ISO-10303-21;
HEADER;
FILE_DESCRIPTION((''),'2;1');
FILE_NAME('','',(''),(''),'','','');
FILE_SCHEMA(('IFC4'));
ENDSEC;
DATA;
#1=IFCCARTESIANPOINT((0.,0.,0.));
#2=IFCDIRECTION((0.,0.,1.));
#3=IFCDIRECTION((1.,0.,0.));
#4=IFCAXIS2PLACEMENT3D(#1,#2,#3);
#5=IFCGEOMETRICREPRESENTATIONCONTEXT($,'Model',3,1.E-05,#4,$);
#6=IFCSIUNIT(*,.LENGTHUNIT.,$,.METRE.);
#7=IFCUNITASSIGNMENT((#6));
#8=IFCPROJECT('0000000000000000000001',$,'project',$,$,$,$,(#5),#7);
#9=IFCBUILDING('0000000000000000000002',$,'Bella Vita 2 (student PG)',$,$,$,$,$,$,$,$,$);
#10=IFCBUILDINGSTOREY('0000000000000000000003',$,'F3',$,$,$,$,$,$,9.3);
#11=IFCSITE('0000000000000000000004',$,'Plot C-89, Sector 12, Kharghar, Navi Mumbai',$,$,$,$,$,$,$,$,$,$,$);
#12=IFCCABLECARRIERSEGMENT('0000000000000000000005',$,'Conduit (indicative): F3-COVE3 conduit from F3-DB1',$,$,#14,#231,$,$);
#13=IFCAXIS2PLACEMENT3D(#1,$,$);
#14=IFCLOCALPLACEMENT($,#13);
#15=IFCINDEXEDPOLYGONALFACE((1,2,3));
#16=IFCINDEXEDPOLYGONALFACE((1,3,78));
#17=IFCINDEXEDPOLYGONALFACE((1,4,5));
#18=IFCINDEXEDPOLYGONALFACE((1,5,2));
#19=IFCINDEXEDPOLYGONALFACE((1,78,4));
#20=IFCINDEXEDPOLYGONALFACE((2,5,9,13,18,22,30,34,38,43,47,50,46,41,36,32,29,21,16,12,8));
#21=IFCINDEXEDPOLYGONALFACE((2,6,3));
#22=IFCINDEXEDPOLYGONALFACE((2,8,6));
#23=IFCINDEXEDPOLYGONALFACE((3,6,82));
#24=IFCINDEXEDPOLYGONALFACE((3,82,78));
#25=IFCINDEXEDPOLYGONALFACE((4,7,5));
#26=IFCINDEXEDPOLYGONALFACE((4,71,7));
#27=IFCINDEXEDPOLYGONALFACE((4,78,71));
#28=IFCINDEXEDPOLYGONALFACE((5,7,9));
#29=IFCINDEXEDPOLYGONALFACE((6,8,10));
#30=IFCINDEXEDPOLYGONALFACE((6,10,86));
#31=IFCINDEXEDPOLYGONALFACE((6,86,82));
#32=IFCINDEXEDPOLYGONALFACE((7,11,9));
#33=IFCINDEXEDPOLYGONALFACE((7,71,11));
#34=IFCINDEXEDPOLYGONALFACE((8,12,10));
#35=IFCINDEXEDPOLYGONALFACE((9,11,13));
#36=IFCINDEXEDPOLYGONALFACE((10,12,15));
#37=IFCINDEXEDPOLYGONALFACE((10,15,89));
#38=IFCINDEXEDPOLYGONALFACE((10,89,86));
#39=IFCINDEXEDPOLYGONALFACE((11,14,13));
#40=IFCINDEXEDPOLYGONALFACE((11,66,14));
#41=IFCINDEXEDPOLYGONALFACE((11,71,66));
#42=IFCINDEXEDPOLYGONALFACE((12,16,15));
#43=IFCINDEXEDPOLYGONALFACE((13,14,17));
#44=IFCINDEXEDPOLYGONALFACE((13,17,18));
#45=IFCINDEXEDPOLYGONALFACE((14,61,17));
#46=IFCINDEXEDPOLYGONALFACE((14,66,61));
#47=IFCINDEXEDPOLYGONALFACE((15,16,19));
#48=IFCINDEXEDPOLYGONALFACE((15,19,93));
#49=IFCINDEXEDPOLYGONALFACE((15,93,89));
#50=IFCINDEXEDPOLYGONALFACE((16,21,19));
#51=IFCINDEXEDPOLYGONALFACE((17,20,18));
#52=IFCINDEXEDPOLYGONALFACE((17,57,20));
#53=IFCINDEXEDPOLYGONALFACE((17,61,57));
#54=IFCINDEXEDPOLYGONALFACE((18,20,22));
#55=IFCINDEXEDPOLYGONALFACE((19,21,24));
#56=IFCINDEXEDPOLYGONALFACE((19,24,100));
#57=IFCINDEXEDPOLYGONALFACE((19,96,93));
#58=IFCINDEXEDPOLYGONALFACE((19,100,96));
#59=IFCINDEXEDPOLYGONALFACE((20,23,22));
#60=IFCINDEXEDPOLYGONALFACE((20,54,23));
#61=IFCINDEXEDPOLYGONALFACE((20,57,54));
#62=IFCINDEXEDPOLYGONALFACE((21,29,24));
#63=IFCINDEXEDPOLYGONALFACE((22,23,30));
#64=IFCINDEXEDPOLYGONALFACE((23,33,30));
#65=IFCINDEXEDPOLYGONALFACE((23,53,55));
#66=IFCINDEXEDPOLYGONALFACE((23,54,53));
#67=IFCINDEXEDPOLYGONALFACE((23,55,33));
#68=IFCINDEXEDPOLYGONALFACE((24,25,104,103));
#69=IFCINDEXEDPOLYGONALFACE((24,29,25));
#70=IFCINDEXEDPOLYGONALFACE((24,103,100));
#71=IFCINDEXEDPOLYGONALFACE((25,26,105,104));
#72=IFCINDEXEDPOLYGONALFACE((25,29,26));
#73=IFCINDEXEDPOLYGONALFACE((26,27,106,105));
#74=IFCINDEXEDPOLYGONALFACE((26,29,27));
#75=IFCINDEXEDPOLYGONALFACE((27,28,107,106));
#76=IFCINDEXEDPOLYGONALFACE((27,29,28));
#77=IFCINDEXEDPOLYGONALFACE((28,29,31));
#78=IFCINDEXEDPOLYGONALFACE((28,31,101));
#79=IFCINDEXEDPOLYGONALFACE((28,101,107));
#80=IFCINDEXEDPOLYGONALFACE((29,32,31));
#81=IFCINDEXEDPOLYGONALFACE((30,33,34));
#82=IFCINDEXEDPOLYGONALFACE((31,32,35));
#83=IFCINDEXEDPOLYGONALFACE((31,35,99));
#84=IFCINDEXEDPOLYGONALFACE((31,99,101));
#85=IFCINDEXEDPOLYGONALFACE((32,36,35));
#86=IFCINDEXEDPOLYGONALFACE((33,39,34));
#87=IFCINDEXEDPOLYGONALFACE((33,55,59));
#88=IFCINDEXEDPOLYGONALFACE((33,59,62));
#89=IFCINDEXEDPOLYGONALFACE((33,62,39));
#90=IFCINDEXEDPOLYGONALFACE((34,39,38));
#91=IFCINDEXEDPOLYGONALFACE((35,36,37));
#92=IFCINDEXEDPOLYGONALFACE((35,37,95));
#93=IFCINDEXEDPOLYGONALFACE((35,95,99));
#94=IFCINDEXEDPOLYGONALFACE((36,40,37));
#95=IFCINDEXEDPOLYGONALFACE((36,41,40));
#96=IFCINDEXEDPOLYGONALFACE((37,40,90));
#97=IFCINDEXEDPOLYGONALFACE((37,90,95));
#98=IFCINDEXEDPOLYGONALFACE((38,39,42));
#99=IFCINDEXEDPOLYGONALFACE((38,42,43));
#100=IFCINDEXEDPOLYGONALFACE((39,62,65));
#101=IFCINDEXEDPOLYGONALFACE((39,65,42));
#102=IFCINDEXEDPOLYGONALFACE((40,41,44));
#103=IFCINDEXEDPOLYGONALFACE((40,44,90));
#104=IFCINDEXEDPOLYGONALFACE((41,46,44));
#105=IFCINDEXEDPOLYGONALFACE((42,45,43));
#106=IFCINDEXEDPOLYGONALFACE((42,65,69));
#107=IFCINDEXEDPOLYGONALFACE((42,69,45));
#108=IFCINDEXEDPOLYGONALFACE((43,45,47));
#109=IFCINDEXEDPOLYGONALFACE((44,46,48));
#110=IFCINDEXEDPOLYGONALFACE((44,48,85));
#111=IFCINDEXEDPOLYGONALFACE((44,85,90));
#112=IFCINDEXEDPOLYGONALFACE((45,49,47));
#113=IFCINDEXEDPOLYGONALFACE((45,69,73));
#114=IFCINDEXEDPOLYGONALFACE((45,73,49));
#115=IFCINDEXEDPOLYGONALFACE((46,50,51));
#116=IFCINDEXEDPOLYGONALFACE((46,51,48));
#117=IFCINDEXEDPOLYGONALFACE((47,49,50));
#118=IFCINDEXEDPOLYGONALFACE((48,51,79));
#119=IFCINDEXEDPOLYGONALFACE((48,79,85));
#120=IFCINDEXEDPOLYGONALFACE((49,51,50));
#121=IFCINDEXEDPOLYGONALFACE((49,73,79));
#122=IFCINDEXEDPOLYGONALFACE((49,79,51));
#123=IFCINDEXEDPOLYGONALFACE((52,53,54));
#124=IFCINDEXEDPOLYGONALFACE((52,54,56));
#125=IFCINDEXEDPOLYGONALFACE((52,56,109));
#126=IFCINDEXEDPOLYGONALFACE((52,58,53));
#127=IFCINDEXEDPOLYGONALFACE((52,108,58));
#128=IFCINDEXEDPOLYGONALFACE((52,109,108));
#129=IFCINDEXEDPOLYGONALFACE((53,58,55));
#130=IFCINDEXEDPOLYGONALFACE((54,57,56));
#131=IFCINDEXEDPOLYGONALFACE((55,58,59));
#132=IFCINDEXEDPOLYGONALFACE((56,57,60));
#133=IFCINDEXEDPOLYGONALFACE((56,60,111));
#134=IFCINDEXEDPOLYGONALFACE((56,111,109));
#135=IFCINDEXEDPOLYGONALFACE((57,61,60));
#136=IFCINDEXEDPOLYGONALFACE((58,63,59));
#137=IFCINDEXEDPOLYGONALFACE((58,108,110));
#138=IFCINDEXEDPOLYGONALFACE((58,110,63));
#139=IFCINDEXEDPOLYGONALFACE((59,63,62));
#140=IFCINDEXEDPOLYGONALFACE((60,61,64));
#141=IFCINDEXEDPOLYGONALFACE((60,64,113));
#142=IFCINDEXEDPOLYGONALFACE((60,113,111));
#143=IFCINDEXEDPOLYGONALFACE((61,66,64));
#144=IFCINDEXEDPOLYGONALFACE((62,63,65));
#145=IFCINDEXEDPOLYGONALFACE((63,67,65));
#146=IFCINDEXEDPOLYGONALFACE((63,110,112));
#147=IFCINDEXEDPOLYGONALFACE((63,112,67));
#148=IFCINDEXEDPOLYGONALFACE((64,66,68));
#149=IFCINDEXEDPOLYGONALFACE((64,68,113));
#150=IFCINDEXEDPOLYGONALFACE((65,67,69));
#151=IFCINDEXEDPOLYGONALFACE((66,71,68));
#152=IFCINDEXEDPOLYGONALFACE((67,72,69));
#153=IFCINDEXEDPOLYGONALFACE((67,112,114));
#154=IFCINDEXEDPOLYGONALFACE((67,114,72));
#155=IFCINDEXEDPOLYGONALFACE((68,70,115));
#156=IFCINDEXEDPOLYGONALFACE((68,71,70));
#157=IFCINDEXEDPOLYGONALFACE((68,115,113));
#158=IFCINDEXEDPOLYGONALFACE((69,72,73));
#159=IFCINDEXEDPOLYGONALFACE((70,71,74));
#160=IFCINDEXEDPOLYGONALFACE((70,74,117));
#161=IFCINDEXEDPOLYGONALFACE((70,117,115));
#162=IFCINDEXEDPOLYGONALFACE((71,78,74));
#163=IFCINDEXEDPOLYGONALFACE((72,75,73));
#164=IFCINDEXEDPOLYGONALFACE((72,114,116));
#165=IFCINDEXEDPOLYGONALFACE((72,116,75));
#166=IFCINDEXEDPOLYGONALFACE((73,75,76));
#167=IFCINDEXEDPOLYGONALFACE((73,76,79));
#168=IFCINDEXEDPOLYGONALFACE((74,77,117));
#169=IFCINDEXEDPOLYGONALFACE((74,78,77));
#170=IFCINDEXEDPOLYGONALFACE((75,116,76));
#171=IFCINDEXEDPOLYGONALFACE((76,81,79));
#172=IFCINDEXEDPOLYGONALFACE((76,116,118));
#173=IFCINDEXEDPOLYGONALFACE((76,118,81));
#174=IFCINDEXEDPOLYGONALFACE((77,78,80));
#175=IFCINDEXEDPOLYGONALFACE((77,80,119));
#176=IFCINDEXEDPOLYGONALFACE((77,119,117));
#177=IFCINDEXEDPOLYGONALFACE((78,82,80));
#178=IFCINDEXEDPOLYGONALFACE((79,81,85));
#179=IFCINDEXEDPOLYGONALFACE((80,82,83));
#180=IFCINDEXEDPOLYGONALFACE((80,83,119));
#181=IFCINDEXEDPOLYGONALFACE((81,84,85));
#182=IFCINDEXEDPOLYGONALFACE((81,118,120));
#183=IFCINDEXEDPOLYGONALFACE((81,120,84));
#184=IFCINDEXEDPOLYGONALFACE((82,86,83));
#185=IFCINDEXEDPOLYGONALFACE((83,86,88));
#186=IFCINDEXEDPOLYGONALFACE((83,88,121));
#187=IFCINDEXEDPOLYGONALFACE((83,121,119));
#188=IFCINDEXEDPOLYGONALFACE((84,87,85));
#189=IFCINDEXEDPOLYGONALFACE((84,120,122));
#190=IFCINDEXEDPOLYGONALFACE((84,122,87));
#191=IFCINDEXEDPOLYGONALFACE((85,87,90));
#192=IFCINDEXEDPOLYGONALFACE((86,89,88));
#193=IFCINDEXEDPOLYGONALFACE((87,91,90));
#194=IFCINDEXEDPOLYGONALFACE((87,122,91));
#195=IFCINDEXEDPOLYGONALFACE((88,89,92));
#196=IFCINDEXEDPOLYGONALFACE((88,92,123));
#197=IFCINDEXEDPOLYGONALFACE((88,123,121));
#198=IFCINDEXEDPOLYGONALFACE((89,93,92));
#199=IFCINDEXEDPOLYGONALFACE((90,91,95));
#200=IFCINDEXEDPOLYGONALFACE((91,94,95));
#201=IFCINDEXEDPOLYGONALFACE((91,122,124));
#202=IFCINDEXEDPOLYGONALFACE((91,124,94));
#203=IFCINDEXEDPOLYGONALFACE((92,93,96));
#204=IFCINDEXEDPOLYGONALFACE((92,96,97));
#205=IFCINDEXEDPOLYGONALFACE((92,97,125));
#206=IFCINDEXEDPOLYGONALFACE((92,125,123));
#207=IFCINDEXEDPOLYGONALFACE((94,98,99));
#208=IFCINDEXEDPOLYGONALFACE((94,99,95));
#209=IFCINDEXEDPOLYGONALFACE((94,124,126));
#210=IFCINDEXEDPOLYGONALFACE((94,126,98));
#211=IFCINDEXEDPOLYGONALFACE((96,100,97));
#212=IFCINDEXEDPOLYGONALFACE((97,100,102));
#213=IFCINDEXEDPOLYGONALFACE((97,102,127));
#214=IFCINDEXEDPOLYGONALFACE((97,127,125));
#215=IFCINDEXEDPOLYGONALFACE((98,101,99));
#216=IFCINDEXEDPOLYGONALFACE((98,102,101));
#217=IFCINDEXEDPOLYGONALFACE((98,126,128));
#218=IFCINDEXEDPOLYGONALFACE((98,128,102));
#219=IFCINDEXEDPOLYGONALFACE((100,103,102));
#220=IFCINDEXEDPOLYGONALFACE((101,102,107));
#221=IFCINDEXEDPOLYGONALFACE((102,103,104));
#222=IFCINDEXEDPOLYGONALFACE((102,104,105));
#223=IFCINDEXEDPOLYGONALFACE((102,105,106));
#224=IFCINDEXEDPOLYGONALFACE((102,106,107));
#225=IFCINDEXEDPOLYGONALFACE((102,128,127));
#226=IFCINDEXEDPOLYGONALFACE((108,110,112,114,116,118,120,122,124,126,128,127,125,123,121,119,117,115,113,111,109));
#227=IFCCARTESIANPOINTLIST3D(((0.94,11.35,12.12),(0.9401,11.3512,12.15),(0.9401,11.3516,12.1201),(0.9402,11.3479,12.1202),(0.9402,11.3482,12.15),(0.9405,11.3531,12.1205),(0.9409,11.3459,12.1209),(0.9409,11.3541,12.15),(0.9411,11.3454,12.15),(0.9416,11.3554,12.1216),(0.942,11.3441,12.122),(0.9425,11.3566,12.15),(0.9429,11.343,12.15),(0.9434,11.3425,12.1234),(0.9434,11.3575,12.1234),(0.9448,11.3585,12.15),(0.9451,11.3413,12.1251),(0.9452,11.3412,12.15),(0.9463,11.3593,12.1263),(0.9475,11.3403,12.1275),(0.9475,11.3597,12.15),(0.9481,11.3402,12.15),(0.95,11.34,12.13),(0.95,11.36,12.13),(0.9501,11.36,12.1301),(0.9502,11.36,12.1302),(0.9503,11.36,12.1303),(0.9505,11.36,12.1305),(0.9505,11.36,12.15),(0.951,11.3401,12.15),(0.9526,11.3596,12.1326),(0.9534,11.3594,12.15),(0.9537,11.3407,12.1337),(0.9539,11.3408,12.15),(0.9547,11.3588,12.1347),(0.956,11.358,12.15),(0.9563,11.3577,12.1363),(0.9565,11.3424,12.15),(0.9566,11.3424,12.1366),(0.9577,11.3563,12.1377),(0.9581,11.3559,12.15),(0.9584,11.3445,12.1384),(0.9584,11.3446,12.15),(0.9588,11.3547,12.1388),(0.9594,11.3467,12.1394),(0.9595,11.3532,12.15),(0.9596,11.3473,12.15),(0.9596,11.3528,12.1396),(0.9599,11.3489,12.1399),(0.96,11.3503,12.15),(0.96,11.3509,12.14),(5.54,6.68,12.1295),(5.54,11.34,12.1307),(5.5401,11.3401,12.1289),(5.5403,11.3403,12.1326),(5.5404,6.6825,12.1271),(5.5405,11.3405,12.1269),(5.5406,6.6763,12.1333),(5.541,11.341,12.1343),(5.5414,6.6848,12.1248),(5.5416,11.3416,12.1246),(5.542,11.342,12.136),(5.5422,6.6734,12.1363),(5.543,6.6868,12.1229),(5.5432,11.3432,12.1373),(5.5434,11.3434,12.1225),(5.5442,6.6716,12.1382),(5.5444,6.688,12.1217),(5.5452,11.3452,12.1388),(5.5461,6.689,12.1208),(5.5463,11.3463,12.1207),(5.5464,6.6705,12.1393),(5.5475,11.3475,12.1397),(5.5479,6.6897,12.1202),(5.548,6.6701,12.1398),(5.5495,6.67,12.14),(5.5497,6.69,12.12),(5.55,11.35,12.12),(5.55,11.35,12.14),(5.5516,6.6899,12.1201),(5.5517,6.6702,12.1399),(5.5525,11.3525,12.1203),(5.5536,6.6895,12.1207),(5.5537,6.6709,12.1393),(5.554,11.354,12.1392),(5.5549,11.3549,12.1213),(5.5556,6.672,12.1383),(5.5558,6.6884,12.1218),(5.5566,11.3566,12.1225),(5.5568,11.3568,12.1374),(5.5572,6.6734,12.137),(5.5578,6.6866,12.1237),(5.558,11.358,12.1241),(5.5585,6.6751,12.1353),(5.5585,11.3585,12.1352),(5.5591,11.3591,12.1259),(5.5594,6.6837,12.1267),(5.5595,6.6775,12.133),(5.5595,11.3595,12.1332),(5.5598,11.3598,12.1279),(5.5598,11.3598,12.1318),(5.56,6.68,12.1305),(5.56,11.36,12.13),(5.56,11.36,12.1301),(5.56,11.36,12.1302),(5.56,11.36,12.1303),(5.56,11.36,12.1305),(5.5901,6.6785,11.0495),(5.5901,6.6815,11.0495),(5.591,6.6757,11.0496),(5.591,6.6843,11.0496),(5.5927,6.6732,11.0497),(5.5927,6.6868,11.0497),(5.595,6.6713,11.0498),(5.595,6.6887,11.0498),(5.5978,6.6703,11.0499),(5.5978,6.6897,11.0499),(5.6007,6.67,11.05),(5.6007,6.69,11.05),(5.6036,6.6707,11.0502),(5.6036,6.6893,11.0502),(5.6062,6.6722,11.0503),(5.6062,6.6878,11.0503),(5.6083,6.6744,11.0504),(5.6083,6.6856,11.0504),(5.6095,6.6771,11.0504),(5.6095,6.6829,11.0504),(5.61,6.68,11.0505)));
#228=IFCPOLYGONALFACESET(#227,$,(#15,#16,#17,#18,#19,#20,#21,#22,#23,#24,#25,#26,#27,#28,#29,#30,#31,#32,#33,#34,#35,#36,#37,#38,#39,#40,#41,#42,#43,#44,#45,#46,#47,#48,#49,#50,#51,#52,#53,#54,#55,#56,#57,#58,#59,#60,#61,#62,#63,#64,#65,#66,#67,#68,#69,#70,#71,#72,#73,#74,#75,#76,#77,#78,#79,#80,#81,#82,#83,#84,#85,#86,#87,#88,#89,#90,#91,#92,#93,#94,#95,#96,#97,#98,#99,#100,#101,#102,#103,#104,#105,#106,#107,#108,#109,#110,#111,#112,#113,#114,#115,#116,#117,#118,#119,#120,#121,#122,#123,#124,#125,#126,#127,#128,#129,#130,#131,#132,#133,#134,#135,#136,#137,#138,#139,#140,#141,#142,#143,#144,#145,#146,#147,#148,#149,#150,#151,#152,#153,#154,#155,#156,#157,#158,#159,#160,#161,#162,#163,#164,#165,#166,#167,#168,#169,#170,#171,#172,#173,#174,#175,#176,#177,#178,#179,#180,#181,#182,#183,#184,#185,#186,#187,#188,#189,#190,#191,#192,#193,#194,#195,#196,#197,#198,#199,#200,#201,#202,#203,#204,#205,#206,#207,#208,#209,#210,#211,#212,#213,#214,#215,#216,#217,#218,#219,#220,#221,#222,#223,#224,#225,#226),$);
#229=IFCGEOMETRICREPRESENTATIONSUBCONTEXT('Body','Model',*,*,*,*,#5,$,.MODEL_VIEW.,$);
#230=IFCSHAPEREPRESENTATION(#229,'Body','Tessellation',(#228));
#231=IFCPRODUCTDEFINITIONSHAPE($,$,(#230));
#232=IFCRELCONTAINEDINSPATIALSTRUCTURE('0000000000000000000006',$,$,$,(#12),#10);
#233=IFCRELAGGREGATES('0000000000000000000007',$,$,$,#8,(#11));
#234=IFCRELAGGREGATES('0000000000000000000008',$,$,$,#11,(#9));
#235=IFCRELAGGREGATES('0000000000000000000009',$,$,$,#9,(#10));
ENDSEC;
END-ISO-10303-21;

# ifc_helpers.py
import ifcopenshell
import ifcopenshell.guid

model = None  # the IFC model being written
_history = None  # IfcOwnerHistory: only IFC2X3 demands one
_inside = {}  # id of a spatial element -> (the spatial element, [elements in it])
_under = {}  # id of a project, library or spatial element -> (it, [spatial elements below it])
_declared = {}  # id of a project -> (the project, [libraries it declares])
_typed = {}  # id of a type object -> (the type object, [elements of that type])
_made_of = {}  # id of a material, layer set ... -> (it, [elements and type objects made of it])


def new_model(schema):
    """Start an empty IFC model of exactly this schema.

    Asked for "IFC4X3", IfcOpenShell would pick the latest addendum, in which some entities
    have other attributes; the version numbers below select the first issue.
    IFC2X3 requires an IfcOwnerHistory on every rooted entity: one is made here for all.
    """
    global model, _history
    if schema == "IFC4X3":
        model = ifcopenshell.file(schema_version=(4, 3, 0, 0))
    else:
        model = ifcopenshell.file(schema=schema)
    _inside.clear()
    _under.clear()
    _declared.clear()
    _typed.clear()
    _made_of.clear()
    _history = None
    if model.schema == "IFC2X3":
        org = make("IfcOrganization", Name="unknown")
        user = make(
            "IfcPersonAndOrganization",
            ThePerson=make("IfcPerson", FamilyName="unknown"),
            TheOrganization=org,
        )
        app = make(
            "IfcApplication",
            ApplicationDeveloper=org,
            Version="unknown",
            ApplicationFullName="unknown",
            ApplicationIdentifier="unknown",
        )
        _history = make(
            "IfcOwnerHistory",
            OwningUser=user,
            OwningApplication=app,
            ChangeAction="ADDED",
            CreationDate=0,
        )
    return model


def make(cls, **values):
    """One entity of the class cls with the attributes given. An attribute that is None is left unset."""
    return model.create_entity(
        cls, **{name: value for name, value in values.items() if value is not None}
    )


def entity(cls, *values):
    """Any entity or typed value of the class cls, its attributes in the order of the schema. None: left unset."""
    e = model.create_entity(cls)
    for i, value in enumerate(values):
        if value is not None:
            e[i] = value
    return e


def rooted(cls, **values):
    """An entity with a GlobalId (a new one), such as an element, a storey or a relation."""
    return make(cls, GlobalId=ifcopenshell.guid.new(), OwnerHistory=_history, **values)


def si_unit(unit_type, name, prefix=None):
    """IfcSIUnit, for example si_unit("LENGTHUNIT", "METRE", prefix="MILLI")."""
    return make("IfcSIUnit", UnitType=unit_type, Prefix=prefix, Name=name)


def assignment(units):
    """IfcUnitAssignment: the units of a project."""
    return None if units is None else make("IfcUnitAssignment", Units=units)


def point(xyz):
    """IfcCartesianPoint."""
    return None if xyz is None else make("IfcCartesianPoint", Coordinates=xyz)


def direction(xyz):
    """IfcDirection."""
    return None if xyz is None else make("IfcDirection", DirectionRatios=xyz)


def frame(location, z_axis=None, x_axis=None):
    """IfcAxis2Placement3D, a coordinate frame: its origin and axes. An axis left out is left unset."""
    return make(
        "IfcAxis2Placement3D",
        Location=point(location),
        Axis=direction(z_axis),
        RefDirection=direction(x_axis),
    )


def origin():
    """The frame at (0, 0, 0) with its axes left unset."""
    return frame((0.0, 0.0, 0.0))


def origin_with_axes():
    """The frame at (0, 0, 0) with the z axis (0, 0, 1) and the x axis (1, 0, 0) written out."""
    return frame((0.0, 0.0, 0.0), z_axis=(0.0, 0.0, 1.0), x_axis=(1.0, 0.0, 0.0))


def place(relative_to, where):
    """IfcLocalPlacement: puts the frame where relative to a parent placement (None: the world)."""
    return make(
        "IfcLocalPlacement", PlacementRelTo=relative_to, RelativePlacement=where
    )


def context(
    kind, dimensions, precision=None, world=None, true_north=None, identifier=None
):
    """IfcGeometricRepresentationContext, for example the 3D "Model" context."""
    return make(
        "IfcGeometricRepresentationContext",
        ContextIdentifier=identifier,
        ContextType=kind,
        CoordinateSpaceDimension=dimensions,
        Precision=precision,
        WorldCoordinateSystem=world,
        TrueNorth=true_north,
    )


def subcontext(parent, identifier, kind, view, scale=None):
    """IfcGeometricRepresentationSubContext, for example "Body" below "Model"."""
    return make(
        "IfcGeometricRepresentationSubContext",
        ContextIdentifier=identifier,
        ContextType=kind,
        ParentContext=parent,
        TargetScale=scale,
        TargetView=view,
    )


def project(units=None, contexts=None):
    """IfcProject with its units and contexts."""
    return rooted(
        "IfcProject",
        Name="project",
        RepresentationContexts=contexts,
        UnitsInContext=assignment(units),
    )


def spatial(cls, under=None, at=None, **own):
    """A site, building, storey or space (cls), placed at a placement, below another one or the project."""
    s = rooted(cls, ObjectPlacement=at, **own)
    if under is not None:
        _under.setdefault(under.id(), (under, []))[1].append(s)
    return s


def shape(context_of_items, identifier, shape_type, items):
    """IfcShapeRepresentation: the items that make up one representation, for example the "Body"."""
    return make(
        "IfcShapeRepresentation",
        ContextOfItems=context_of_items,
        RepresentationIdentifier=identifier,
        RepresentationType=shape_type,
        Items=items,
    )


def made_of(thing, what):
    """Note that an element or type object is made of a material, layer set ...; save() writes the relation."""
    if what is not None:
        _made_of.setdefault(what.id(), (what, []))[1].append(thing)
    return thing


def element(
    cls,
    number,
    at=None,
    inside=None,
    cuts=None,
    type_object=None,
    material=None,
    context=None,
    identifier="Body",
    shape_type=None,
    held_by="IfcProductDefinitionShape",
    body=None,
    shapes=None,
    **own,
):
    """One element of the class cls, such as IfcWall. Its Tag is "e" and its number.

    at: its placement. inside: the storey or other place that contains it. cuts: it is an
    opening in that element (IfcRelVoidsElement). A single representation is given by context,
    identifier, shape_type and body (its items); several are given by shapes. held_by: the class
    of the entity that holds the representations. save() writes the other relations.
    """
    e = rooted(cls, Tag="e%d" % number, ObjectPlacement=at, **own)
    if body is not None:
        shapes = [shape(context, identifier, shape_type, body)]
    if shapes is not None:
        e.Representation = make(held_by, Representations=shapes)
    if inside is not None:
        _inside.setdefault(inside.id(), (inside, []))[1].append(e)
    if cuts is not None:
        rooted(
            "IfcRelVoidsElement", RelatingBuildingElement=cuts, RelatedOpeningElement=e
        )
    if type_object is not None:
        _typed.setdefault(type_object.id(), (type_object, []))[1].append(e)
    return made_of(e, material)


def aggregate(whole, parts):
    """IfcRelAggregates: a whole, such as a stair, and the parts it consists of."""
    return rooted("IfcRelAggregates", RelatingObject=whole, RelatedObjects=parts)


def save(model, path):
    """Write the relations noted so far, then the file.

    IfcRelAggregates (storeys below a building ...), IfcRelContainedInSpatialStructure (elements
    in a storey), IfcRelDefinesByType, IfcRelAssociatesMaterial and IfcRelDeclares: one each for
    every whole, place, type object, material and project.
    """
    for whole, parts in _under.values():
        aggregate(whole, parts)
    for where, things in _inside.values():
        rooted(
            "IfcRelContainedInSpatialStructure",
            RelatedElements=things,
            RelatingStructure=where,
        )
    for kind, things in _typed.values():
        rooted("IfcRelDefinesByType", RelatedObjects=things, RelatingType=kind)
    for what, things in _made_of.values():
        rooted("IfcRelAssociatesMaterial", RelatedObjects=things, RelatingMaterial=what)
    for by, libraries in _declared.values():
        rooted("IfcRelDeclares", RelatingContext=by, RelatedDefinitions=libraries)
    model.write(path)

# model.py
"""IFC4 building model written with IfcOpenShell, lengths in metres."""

from ifc_helpers import new_model, entity, si_unit, origin, origin_with_axes, place, context, subcontext, project, spatial, element, save


model = new_model("IFC4")

# Units and contexts
model_context = context("Model", 3, precision=1e-05, world=origin_with_axes())
body_context = subcontext(model_context, "Body", "Model", "MODEL_VIEW")
ifc_project = project(units=[si_unit("LENGTHUNIT", "METRE")], contexts=[model_context])

# Site, building, storey
site = spatial("IfcSite", under=ifc_project, Name="Plot C-89, Sector 12, Kharghar, Navi Mumbai")
building = spatial("IfcBuilding", under=site, Name="Bella Vita 2 (student PG)")
storey = spatial("IfcBuildingStorey", under=building, Name="F3", Elevation=9.3)

# Cable carrier segment
cable_carrier_segment_1_placement = place(None, origin())
element("IfcCableCarrierSegment", 1, at=cable_carrier_segment_1_placement, inside=storey, Name="Conduit (indicative): F3-COVE3 conduit from F3-DB1", context=body_context, shape_type="AdvancedSweptSolid", body=[
    entity("IfcSweptDiskSolid", entity("IfcPolyline", [entity("IfcCartesianPoint", [5.6, 6.68, 11.05]), entity("IfcCartesianPoint", [5.55, 6.68, 12.13]), entity("IfcCartesianPoint", [5.55, 11.35, 12.13]), entity("IfcCartesianPoint", [0.95, 11.35, 12.13]), entity("IfcCartesianPoint", [0.95, 11.35, 12.15])]), 0.01),
])

save(model, "model.ifc")
